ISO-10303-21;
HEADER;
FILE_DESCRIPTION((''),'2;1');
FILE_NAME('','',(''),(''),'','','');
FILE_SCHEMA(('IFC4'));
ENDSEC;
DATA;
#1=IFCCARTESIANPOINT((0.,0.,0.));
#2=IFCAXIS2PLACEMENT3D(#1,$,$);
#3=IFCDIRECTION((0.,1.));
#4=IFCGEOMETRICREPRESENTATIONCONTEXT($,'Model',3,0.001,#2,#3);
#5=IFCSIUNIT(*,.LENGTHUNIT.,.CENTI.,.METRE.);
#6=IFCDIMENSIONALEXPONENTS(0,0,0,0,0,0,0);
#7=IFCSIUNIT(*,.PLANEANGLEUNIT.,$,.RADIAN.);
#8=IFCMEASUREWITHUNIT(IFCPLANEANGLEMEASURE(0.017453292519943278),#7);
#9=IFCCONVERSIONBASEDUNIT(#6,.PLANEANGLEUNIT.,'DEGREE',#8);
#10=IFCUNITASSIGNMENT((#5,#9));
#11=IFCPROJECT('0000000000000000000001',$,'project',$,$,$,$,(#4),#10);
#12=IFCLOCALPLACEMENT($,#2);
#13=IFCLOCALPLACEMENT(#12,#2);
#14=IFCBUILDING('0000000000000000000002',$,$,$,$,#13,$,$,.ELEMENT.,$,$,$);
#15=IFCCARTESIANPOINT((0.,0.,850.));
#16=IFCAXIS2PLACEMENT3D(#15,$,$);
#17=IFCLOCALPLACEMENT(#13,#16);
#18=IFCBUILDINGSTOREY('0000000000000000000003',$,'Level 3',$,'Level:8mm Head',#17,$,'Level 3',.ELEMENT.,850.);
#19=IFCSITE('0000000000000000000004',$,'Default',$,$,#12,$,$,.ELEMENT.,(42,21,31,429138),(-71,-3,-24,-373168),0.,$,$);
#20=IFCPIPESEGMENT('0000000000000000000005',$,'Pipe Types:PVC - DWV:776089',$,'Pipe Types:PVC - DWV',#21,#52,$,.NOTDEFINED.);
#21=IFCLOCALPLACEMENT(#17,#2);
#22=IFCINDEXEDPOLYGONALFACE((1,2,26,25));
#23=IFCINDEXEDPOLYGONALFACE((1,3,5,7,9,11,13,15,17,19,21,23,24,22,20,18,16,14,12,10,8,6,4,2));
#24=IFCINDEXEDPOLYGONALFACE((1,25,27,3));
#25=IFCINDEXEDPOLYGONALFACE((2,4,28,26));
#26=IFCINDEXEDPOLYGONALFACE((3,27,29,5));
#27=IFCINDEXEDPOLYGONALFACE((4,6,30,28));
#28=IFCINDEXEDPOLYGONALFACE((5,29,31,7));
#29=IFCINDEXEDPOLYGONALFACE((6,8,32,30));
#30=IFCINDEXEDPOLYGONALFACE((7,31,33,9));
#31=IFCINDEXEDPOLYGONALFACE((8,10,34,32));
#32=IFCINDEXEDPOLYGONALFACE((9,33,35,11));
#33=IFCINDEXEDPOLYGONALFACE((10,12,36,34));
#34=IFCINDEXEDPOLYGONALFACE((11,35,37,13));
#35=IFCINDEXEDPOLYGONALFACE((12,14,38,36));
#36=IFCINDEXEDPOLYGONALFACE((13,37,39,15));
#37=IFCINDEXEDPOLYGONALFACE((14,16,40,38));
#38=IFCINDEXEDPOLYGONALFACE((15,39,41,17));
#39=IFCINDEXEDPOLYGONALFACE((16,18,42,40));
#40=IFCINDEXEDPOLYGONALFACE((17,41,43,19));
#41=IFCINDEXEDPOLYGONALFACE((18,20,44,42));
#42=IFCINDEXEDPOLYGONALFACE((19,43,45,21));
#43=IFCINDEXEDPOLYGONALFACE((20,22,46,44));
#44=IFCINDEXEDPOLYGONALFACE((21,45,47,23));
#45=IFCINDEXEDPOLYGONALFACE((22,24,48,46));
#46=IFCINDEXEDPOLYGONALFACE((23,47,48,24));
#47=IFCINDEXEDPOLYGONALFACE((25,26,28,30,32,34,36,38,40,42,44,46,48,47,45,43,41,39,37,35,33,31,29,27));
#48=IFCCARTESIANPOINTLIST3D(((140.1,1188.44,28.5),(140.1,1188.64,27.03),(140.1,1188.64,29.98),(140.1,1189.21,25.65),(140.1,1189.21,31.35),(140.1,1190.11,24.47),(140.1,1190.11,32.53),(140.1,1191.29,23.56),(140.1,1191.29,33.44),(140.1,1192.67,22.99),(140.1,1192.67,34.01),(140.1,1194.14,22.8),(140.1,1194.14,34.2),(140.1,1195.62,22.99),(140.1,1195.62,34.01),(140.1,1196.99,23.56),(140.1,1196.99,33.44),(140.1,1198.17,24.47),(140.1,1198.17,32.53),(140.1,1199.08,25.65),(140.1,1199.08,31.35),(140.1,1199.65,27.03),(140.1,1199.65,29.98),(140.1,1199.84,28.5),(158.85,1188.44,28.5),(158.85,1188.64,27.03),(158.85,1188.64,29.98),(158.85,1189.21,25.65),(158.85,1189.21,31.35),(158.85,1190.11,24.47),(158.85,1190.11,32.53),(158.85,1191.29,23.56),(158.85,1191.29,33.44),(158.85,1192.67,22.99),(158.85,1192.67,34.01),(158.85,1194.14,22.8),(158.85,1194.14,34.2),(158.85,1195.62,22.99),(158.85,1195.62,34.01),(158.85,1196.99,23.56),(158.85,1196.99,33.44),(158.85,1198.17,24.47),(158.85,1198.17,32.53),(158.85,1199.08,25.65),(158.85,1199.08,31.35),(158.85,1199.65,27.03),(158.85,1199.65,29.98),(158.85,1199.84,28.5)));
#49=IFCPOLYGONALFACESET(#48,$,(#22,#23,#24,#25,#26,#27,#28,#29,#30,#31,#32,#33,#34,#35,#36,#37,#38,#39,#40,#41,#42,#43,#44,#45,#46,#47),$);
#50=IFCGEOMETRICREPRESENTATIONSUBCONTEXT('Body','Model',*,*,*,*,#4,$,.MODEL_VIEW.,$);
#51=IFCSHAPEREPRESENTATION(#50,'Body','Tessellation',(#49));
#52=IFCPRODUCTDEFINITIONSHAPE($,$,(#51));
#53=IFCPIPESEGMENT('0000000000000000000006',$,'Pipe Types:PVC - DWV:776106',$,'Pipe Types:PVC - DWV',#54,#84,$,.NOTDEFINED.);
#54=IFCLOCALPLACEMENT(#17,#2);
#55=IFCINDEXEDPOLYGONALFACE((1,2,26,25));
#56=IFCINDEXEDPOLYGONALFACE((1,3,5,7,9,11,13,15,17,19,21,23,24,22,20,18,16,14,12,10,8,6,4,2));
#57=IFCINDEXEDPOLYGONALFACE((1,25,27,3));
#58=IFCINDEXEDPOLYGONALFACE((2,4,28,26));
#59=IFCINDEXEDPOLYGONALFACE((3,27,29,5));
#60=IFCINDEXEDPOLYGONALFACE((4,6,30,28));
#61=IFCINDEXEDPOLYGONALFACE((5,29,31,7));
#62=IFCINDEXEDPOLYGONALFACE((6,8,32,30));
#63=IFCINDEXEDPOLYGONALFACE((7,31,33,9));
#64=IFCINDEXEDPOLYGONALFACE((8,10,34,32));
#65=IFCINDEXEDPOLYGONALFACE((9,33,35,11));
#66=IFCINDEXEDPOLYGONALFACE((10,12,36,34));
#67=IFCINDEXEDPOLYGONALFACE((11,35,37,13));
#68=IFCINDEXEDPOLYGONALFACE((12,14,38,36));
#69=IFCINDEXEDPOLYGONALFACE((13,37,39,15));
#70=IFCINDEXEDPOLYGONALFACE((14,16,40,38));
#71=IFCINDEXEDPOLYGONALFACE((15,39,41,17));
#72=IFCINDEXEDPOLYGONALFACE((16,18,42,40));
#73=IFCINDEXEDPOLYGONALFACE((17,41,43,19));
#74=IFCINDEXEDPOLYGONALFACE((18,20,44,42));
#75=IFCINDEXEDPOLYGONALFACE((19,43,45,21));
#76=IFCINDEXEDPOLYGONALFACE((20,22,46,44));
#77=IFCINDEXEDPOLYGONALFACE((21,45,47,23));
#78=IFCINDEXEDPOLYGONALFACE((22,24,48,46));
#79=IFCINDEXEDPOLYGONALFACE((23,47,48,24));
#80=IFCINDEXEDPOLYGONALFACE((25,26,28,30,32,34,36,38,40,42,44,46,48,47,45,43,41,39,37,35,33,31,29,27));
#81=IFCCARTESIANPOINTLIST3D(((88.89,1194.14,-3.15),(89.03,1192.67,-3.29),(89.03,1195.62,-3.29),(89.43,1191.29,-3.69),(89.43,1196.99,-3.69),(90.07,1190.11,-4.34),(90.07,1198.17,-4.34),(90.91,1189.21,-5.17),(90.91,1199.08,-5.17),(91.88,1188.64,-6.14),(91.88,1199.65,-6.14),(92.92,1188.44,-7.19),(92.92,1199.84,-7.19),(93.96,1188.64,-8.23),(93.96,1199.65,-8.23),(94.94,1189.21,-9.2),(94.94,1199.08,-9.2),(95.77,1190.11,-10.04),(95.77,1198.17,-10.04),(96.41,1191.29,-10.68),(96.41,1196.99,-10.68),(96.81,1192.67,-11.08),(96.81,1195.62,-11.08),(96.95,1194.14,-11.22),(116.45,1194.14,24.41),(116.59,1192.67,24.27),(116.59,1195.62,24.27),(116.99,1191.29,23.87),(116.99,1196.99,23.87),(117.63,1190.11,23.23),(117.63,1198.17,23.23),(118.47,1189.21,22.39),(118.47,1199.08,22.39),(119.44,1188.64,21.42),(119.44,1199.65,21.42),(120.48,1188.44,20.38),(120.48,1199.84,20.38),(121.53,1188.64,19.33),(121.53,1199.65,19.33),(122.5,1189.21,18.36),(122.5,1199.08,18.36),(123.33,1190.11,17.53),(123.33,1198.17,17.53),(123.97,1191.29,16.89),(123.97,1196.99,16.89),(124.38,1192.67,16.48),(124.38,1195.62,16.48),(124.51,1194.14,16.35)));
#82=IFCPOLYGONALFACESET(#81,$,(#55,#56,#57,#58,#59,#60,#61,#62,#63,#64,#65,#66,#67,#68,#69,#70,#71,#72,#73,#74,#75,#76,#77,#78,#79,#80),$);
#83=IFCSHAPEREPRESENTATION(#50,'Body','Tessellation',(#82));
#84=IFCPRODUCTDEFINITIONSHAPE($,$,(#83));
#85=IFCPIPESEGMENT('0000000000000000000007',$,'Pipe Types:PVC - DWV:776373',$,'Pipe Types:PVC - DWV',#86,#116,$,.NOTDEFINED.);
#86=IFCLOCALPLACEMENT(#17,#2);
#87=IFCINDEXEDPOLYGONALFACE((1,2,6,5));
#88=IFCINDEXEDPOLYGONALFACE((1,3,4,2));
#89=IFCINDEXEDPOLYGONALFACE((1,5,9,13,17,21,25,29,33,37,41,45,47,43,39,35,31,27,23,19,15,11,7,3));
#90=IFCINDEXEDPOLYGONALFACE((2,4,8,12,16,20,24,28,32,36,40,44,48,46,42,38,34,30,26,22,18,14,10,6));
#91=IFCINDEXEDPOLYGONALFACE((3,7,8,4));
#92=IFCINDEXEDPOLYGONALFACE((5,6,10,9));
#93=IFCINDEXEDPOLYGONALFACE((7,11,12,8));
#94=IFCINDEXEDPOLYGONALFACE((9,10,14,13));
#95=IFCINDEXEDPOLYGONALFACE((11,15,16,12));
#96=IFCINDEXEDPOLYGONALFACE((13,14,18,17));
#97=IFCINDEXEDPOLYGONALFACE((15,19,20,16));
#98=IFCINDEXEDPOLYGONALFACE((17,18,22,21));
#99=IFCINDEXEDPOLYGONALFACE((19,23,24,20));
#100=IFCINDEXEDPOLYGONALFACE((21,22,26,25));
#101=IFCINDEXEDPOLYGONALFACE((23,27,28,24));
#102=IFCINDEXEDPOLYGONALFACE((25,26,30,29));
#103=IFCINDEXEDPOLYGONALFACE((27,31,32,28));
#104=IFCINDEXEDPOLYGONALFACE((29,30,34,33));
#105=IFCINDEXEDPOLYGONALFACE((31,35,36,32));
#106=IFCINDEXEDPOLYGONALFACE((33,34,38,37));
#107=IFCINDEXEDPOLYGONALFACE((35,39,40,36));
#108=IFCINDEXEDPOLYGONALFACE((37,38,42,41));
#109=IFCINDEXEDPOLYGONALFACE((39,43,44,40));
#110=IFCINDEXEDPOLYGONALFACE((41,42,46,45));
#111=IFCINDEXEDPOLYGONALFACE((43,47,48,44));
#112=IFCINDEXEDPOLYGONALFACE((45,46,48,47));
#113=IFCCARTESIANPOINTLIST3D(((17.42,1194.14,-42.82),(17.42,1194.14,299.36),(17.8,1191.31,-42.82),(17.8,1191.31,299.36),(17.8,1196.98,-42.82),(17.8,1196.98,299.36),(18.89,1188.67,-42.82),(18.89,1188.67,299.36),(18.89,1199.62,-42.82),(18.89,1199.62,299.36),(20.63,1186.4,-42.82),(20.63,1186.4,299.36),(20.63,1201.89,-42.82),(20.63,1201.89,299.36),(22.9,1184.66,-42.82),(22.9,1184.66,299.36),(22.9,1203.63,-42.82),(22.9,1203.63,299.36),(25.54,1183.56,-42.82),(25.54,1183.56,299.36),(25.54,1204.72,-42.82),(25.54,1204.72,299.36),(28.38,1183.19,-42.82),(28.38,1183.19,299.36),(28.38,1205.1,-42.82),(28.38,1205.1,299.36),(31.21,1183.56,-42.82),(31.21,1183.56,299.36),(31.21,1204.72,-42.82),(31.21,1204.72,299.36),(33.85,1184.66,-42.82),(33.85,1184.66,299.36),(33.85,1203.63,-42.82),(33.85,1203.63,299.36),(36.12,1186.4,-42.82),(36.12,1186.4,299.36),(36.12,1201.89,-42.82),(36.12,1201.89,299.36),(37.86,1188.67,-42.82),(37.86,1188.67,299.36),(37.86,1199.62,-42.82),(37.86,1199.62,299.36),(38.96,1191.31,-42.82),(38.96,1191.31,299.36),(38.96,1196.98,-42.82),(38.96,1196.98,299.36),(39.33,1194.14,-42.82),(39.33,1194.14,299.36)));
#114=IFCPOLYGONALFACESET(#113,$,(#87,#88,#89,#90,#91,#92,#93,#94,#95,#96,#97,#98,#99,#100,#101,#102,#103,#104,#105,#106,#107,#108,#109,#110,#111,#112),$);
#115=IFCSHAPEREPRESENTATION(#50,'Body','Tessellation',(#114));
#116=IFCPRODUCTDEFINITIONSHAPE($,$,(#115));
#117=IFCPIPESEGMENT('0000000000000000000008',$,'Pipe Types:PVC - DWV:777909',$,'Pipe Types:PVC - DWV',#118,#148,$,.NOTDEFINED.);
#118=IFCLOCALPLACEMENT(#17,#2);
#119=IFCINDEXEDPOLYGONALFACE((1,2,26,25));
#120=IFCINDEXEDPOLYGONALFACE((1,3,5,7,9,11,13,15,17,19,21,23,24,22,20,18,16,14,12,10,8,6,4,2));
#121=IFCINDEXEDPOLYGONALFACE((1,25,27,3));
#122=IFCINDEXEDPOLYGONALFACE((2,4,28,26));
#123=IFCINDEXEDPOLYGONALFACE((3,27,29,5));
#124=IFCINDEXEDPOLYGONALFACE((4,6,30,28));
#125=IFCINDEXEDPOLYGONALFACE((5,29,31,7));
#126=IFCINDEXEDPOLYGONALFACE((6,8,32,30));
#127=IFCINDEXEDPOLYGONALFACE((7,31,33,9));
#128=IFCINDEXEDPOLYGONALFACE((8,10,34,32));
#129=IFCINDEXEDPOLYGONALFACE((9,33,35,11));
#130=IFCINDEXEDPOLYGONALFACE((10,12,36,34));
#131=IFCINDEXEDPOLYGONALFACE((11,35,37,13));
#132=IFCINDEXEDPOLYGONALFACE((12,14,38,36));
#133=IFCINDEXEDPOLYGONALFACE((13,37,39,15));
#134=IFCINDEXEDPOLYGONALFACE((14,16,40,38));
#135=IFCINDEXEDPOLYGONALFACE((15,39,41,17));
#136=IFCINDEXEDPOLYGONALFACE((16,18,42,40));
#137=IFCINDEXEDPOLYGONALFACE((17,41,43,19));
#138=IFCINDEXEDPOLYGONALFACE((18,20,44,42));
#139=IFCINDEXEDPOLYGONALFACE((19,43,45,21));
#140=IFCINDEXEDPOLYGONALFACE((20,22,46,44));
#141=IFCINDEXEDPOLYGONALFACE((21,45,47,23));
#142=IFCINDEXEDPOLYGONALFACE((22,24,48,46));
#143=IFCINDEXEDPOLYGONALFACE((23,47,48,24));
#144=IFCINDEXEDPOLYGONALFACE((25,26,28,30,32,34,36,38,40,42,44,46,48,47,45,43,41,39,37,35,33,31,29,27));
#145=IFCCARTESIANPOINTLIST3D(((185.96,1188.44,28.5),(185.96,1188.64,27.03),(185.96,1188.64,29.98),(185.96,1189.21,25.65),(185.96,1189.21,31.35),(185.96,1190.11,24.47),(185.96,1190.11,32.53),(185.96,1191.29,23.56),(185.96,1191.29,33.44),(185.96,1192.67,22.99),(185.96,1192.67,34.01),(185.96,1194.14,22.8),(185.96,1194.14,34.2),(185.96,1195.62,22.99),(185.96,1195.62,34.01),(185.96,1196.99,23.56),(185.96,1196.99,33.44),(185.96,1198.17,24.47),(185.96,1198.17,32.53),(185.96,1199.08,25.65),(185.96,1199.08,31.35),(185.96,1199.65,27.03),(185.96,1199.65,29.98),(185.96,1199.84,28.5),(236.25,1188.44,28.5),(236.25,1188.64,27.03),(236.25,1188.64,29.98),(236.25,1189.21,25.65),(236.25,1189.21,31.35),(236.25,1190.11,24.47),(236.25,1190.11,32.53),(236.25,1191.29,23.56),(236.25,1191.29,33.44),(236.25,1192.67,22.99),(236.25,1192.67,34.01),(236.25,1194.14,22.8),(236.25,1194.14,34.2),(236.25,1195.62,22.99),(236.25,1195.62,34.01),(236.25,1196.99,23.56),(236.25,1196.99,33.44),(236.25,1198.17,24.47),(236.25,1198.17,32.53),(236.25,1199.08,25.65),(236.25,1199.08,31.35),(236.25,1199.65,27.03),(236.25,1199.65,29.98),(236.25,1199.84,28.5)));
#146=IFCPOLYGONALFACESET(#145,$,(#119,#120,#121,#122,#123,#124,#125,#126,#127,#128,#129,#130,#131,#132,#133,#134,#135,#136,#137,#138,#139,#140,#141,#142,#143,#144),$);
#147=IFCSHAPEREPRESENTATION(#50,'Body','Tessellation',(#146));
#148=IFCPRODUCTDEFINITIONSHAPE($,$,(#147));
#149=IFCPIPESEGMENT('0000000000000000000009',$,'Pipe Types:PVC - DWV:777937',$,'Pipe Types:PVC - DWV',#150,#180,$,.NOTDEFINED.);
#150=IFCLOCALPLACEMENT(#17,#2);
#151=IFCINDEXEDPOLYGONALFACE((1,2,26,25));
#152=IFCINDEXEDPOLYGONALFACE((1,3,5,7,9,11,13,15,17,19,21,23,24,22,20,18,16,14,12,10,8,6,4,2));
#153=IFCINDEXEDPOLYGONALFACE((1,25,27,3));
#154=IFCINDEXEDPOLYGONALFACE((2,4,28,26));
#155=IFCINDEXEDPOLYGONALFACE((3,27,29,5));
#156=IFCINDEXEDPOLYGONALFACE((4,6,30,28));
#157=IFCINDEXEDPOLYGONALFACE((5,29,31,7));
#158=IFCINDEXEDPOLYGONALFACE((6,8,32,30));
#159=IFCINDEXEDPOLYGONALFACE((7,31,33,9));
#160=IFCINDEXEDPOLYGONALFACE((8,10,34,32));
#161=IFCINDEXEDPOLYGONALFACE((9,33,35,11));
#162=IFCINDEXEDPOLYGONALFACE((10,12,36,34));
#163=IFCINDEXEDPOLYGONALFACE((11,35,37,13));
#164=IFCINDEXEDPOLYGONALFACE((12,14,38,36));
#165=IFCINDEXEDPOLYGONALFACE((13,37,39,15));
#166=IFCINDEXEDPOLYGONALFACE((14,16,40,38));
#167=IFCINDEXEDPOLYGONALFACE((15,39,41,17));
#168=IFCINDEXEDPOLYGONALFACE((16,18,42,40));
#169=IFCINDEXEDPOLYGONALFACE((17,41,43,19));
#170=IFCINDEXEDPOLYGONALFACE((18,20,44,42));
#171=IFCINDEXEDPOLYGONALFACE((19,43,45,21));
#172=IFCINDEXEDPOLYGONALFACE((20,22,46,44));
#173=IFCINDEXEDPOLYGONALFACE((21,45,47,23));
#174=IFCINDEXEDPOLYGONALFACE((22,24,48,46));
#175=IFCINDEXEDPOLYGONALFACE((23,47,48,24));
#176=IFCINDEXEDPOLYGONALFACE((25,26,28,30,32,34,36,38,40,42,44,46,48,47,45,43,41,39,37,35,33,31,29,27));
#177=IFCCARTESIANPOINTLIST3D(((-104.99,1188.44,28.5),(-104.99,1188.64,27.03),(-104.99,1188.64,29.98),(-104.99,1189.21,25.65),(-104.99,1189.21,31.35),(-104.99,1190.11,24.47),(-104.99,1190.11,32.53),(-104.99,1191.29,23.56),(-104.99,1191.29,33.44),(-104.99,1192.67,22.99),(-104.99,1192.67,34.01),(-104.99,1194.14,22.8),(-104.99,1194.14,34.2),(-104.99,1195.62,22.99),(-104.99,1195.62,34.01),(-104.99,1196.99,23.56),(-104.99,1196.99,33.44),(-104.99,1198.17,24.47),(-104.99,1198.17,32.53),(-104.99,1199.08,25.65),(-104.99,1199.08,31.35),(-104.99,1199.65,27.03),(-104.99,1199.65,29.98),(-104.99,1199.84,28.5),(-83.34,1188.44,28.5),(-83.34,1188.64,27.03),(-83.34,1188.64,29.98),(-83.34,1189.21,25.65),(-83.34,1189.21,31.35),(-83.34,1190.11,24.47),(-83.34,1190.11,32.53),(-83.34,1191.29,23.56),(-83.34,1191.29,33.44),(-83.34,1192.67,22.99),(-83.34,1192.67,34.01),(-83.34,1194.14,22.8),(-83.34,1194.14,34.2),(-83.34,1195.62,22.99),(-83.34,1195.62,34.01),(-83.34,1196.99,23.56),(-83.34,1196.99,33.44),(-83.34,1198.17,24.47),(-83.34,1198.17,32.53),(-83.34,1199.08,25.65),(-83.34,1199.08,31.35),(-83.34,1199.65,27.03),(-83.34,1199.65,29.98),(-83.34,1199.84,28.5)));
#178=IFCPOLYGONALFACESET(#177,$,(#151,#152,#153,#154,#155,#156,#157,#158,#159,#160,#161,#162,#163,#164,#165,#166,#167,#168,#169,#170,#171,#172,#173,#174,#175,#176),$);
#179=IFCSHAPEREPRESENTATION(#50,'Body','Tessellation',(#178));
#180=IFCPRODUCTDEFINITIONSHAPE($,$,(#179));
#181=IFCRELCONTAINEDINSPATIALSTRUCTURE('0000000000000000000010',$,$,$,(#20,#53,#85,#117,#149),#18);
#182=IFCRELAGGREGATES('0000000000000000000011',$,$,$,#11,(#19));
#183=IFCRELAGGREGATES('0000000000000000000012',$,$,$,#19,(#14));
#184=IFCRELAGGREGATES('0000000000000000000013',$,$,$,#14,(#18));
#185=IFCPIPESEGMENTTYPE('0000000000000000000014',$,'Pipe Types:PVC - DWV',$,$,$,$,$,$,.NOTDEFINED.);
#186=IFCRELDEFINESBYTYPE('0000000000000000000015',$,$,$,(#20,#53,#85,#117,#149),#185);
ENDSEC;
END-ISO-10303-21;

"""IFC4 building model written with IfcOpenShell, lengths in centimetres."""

from ifc_helpers import new_model, entity, si_unit, converted_unit, direction, frame, origin, place, context, subcontext, project, spatial, arc, indexed_curve, outline, extrude, type_object, element, save


model = new_model("IFC4")

# Units and contexts
model_context = context("Model", 3, precision=0.001, world=origin(), true_north=direction((0.0, 1.0)))
body_context = subcontext(model_context, "Body", "Model", "MODEL_VIEW")
ifc_project = project(units=[si_unit("LENGTHUNIT", "METRE", prefix="CENTI"), converted_unit("PLANEANGLEUNIT", "DEGREE", entity("IfcPlaneAngleMeasure", 0.017453292519943278), si_unit("PLANEANGLEUNIT", "RADIAN"), dimensions=[0, 0, 0, 0, 0, 0, 0])], contexts=[model_context])

# Site, building, storey
site_placement = place(None, origin())
site = spatial("IfcSite", under=ifc_project, at=site_placement, Name="Default", CompositionType="ELEMENT", RefLatitude=(42, 21, 31, 429138), RefLongitude=(-71, -3, -24, -373168), RefElevation=0.0)
building_placement = place(site_placement, origin())
building = spatial("IfcBuilding", under=site, at=building_placement, CompositionType="ELEMENT")
storey_placement = place(building_placement, frame((0.0, 0.0, 850.0)))
storey = spatial("IfcBuildingStorey", under=building, at=storey_placement, Name="Level 3", ObjectType="Level:8mm Head", LongName="Level 3", CompositionType="ELEMENT", Elevation=850.0)

# Pipe segments
pipe_segment_type = type_object("IfcPipeSegmentType", Name="Pipe Types:PVC - DWV", PredefinedType="NOTDEFINED")
pipe_segment_1_placement = place(storey_placement, origin())
element("IfcPipeSegment", 1, at=pipe_segment_1_placement, inside=storey, type_object=pipe_segment_type, Name="Pipe Types:PVC - DWV:776089", ObjectType="Pipe Types:PVC - DWV", PredefinedType="NOTDEFINED", context=body_context, shape_type="SweptSolid", body=[
    extrude(outline(indexed_curve([(5.7, 0.0), (4.03, 4.03), (0.0, 5.7), (-4.03, 4.03), (-5.7, 0.0), (-4.03, -4.03), (0.0, -5.7), (4.03, -4.03)], segments=[arc(1, 2, 3), arc(3, 4, 5), arc(5, 6, 7), arc(7, 8, 1)], self_intersect=False)), frame((140.1, 1194.14, 28.5), z_axis=(1.0, 0.0, 0.0), x_axis=(0.0, 1.0, 0.0)), (0.0, 0.0, 1.0), 18.76),
])
pipe_segment_2_placement = place(storey_placement, origin())
element("IfcPipeSegment", 2, at=pipe_segment_2_placement, inside=storey, type_object=pipe_segment_type, Name="Pipe Types:PVC - DWV:776106", ObjectType="Pipe Types:PVC - DWV", PredefinedType="NOTDEFINED", context=body_context, shape_type="SweptSolid", body=[
    extrude(outline(indexed_curve([(5.7, 0.0), (4.03, 4.03), (0.0, 5.7), (-4.03, 4.03), (-5.7, 0.0), (-4.03, -4.03), (0.0, -5.7), (4.03, -4.03)], segments=[arc(1, 2, 3), arc(3, 4, 5), arc(5, 6, 7), arc(7, 8, 1)], self_intersect=False)), frame((92.92, 1194.14, -7.19), z_axis=(0.707107, 0.0, 0.707107), x_axis=(0.0, -1.0, 0.0)), (0.0, 0.0, 1.0), 38.98),
])
pipe_segment_3_placement = place(storey_placement, origin())
element("IfcPipeSegment", 3, at=pipe_segment_3_placement, inside=storey, type_object=pipe_segment_type, Name="Pipe Types:PVC - DWV:776373", ObjectType="Pipe Types:PVC - DWV", PredefinedType="NOTDEFINED", context=body_context, shape_type="SweptSolid", body=[
    extrude(outline(indexed_curve([(10.95, 0.0), (7.75, 7.75), (0.0, 10.95), (-7.75, 7.75), (-10.95, 0.0), (-7.75, -7.75), (0.0, -10.95), (7.75, -7.75)], segments=[arc(1, 2, 3), arc(3, 4, 5), arc(5, 6, 7), arc(7, 8, 1)], self_intersect=False)), frame((28.38, 1194.14, -42.82)), (0.0, 0.0, 1.0), 342.18),
])
pipe_segment_4_placement = place(storey_placement, origin())
element("IfcPipeSegment", 4, at=pipe_segment_4_placement, inside=storey, type_object=pipe_segment_type, Name="Pipe Types:PVC - DWV:777909", ObjectType="Pipe Types:PVC - DWV", PredefinedType="NOTDEFINED", context=body_context, shape_type="SweptSolid", body=[
    extrude(outline(indexed_curve([(5.7, 0.0), (4.03, 4.03), (0.0, 5.7), (-4.03, 4.03), (-5.7, 0.0), (-4.03, -4.03), (0.0, -5.7), (4.03, -4.03)], segments=[arc(1, 2, 3), arc(3, 4, 5), arc(5, 6, 7), arc(7, 8, 1)], self_intersect=False)), frame((185.96, 1194.14, 28.5), z_axis=(1.0, 0.0, 0.0), x_axis=(0.0, 1.0, 0.0)), (0.0, 0.0, 1.0), 50.29),
])
pipe_segment_5_placement = place(storey_placement, origin())
element("IfcPipeSegment", 5, at=pipe_segment_5_placement, inside=storey, type_object=pipe_segment_type, Name="Pipe Types:PVC - DWV:777937", ObjectType="Pipe Types:PVC - DWV", PredefinedType="NOTDEFINED", context=body_context, shape_type="SweptSolid", body=[
    extrude(outline(indexed_curve([(5.7, 0.0), (4.03, 4.03), (0.0, 5.7), (-4.03, 4.03), (-5.7, 0.0), (-4.03, -4.03), (0.0, -5.7), (4.03, -4.03)], segments=[arc(1, 2, 3), arc(3, 4, 5), arc(5, 6, 7), arc(7, 8, 1)], self_intersect=False)), frame((-104.99, 1194.14, 28.5), z_axis=(1.0, 0.0, 0.0), x_axis=(0.0, 1.0, 0.0)), (0.0, 0.0, 1.0), 21.65),
])

save(model, "model.ifc")
